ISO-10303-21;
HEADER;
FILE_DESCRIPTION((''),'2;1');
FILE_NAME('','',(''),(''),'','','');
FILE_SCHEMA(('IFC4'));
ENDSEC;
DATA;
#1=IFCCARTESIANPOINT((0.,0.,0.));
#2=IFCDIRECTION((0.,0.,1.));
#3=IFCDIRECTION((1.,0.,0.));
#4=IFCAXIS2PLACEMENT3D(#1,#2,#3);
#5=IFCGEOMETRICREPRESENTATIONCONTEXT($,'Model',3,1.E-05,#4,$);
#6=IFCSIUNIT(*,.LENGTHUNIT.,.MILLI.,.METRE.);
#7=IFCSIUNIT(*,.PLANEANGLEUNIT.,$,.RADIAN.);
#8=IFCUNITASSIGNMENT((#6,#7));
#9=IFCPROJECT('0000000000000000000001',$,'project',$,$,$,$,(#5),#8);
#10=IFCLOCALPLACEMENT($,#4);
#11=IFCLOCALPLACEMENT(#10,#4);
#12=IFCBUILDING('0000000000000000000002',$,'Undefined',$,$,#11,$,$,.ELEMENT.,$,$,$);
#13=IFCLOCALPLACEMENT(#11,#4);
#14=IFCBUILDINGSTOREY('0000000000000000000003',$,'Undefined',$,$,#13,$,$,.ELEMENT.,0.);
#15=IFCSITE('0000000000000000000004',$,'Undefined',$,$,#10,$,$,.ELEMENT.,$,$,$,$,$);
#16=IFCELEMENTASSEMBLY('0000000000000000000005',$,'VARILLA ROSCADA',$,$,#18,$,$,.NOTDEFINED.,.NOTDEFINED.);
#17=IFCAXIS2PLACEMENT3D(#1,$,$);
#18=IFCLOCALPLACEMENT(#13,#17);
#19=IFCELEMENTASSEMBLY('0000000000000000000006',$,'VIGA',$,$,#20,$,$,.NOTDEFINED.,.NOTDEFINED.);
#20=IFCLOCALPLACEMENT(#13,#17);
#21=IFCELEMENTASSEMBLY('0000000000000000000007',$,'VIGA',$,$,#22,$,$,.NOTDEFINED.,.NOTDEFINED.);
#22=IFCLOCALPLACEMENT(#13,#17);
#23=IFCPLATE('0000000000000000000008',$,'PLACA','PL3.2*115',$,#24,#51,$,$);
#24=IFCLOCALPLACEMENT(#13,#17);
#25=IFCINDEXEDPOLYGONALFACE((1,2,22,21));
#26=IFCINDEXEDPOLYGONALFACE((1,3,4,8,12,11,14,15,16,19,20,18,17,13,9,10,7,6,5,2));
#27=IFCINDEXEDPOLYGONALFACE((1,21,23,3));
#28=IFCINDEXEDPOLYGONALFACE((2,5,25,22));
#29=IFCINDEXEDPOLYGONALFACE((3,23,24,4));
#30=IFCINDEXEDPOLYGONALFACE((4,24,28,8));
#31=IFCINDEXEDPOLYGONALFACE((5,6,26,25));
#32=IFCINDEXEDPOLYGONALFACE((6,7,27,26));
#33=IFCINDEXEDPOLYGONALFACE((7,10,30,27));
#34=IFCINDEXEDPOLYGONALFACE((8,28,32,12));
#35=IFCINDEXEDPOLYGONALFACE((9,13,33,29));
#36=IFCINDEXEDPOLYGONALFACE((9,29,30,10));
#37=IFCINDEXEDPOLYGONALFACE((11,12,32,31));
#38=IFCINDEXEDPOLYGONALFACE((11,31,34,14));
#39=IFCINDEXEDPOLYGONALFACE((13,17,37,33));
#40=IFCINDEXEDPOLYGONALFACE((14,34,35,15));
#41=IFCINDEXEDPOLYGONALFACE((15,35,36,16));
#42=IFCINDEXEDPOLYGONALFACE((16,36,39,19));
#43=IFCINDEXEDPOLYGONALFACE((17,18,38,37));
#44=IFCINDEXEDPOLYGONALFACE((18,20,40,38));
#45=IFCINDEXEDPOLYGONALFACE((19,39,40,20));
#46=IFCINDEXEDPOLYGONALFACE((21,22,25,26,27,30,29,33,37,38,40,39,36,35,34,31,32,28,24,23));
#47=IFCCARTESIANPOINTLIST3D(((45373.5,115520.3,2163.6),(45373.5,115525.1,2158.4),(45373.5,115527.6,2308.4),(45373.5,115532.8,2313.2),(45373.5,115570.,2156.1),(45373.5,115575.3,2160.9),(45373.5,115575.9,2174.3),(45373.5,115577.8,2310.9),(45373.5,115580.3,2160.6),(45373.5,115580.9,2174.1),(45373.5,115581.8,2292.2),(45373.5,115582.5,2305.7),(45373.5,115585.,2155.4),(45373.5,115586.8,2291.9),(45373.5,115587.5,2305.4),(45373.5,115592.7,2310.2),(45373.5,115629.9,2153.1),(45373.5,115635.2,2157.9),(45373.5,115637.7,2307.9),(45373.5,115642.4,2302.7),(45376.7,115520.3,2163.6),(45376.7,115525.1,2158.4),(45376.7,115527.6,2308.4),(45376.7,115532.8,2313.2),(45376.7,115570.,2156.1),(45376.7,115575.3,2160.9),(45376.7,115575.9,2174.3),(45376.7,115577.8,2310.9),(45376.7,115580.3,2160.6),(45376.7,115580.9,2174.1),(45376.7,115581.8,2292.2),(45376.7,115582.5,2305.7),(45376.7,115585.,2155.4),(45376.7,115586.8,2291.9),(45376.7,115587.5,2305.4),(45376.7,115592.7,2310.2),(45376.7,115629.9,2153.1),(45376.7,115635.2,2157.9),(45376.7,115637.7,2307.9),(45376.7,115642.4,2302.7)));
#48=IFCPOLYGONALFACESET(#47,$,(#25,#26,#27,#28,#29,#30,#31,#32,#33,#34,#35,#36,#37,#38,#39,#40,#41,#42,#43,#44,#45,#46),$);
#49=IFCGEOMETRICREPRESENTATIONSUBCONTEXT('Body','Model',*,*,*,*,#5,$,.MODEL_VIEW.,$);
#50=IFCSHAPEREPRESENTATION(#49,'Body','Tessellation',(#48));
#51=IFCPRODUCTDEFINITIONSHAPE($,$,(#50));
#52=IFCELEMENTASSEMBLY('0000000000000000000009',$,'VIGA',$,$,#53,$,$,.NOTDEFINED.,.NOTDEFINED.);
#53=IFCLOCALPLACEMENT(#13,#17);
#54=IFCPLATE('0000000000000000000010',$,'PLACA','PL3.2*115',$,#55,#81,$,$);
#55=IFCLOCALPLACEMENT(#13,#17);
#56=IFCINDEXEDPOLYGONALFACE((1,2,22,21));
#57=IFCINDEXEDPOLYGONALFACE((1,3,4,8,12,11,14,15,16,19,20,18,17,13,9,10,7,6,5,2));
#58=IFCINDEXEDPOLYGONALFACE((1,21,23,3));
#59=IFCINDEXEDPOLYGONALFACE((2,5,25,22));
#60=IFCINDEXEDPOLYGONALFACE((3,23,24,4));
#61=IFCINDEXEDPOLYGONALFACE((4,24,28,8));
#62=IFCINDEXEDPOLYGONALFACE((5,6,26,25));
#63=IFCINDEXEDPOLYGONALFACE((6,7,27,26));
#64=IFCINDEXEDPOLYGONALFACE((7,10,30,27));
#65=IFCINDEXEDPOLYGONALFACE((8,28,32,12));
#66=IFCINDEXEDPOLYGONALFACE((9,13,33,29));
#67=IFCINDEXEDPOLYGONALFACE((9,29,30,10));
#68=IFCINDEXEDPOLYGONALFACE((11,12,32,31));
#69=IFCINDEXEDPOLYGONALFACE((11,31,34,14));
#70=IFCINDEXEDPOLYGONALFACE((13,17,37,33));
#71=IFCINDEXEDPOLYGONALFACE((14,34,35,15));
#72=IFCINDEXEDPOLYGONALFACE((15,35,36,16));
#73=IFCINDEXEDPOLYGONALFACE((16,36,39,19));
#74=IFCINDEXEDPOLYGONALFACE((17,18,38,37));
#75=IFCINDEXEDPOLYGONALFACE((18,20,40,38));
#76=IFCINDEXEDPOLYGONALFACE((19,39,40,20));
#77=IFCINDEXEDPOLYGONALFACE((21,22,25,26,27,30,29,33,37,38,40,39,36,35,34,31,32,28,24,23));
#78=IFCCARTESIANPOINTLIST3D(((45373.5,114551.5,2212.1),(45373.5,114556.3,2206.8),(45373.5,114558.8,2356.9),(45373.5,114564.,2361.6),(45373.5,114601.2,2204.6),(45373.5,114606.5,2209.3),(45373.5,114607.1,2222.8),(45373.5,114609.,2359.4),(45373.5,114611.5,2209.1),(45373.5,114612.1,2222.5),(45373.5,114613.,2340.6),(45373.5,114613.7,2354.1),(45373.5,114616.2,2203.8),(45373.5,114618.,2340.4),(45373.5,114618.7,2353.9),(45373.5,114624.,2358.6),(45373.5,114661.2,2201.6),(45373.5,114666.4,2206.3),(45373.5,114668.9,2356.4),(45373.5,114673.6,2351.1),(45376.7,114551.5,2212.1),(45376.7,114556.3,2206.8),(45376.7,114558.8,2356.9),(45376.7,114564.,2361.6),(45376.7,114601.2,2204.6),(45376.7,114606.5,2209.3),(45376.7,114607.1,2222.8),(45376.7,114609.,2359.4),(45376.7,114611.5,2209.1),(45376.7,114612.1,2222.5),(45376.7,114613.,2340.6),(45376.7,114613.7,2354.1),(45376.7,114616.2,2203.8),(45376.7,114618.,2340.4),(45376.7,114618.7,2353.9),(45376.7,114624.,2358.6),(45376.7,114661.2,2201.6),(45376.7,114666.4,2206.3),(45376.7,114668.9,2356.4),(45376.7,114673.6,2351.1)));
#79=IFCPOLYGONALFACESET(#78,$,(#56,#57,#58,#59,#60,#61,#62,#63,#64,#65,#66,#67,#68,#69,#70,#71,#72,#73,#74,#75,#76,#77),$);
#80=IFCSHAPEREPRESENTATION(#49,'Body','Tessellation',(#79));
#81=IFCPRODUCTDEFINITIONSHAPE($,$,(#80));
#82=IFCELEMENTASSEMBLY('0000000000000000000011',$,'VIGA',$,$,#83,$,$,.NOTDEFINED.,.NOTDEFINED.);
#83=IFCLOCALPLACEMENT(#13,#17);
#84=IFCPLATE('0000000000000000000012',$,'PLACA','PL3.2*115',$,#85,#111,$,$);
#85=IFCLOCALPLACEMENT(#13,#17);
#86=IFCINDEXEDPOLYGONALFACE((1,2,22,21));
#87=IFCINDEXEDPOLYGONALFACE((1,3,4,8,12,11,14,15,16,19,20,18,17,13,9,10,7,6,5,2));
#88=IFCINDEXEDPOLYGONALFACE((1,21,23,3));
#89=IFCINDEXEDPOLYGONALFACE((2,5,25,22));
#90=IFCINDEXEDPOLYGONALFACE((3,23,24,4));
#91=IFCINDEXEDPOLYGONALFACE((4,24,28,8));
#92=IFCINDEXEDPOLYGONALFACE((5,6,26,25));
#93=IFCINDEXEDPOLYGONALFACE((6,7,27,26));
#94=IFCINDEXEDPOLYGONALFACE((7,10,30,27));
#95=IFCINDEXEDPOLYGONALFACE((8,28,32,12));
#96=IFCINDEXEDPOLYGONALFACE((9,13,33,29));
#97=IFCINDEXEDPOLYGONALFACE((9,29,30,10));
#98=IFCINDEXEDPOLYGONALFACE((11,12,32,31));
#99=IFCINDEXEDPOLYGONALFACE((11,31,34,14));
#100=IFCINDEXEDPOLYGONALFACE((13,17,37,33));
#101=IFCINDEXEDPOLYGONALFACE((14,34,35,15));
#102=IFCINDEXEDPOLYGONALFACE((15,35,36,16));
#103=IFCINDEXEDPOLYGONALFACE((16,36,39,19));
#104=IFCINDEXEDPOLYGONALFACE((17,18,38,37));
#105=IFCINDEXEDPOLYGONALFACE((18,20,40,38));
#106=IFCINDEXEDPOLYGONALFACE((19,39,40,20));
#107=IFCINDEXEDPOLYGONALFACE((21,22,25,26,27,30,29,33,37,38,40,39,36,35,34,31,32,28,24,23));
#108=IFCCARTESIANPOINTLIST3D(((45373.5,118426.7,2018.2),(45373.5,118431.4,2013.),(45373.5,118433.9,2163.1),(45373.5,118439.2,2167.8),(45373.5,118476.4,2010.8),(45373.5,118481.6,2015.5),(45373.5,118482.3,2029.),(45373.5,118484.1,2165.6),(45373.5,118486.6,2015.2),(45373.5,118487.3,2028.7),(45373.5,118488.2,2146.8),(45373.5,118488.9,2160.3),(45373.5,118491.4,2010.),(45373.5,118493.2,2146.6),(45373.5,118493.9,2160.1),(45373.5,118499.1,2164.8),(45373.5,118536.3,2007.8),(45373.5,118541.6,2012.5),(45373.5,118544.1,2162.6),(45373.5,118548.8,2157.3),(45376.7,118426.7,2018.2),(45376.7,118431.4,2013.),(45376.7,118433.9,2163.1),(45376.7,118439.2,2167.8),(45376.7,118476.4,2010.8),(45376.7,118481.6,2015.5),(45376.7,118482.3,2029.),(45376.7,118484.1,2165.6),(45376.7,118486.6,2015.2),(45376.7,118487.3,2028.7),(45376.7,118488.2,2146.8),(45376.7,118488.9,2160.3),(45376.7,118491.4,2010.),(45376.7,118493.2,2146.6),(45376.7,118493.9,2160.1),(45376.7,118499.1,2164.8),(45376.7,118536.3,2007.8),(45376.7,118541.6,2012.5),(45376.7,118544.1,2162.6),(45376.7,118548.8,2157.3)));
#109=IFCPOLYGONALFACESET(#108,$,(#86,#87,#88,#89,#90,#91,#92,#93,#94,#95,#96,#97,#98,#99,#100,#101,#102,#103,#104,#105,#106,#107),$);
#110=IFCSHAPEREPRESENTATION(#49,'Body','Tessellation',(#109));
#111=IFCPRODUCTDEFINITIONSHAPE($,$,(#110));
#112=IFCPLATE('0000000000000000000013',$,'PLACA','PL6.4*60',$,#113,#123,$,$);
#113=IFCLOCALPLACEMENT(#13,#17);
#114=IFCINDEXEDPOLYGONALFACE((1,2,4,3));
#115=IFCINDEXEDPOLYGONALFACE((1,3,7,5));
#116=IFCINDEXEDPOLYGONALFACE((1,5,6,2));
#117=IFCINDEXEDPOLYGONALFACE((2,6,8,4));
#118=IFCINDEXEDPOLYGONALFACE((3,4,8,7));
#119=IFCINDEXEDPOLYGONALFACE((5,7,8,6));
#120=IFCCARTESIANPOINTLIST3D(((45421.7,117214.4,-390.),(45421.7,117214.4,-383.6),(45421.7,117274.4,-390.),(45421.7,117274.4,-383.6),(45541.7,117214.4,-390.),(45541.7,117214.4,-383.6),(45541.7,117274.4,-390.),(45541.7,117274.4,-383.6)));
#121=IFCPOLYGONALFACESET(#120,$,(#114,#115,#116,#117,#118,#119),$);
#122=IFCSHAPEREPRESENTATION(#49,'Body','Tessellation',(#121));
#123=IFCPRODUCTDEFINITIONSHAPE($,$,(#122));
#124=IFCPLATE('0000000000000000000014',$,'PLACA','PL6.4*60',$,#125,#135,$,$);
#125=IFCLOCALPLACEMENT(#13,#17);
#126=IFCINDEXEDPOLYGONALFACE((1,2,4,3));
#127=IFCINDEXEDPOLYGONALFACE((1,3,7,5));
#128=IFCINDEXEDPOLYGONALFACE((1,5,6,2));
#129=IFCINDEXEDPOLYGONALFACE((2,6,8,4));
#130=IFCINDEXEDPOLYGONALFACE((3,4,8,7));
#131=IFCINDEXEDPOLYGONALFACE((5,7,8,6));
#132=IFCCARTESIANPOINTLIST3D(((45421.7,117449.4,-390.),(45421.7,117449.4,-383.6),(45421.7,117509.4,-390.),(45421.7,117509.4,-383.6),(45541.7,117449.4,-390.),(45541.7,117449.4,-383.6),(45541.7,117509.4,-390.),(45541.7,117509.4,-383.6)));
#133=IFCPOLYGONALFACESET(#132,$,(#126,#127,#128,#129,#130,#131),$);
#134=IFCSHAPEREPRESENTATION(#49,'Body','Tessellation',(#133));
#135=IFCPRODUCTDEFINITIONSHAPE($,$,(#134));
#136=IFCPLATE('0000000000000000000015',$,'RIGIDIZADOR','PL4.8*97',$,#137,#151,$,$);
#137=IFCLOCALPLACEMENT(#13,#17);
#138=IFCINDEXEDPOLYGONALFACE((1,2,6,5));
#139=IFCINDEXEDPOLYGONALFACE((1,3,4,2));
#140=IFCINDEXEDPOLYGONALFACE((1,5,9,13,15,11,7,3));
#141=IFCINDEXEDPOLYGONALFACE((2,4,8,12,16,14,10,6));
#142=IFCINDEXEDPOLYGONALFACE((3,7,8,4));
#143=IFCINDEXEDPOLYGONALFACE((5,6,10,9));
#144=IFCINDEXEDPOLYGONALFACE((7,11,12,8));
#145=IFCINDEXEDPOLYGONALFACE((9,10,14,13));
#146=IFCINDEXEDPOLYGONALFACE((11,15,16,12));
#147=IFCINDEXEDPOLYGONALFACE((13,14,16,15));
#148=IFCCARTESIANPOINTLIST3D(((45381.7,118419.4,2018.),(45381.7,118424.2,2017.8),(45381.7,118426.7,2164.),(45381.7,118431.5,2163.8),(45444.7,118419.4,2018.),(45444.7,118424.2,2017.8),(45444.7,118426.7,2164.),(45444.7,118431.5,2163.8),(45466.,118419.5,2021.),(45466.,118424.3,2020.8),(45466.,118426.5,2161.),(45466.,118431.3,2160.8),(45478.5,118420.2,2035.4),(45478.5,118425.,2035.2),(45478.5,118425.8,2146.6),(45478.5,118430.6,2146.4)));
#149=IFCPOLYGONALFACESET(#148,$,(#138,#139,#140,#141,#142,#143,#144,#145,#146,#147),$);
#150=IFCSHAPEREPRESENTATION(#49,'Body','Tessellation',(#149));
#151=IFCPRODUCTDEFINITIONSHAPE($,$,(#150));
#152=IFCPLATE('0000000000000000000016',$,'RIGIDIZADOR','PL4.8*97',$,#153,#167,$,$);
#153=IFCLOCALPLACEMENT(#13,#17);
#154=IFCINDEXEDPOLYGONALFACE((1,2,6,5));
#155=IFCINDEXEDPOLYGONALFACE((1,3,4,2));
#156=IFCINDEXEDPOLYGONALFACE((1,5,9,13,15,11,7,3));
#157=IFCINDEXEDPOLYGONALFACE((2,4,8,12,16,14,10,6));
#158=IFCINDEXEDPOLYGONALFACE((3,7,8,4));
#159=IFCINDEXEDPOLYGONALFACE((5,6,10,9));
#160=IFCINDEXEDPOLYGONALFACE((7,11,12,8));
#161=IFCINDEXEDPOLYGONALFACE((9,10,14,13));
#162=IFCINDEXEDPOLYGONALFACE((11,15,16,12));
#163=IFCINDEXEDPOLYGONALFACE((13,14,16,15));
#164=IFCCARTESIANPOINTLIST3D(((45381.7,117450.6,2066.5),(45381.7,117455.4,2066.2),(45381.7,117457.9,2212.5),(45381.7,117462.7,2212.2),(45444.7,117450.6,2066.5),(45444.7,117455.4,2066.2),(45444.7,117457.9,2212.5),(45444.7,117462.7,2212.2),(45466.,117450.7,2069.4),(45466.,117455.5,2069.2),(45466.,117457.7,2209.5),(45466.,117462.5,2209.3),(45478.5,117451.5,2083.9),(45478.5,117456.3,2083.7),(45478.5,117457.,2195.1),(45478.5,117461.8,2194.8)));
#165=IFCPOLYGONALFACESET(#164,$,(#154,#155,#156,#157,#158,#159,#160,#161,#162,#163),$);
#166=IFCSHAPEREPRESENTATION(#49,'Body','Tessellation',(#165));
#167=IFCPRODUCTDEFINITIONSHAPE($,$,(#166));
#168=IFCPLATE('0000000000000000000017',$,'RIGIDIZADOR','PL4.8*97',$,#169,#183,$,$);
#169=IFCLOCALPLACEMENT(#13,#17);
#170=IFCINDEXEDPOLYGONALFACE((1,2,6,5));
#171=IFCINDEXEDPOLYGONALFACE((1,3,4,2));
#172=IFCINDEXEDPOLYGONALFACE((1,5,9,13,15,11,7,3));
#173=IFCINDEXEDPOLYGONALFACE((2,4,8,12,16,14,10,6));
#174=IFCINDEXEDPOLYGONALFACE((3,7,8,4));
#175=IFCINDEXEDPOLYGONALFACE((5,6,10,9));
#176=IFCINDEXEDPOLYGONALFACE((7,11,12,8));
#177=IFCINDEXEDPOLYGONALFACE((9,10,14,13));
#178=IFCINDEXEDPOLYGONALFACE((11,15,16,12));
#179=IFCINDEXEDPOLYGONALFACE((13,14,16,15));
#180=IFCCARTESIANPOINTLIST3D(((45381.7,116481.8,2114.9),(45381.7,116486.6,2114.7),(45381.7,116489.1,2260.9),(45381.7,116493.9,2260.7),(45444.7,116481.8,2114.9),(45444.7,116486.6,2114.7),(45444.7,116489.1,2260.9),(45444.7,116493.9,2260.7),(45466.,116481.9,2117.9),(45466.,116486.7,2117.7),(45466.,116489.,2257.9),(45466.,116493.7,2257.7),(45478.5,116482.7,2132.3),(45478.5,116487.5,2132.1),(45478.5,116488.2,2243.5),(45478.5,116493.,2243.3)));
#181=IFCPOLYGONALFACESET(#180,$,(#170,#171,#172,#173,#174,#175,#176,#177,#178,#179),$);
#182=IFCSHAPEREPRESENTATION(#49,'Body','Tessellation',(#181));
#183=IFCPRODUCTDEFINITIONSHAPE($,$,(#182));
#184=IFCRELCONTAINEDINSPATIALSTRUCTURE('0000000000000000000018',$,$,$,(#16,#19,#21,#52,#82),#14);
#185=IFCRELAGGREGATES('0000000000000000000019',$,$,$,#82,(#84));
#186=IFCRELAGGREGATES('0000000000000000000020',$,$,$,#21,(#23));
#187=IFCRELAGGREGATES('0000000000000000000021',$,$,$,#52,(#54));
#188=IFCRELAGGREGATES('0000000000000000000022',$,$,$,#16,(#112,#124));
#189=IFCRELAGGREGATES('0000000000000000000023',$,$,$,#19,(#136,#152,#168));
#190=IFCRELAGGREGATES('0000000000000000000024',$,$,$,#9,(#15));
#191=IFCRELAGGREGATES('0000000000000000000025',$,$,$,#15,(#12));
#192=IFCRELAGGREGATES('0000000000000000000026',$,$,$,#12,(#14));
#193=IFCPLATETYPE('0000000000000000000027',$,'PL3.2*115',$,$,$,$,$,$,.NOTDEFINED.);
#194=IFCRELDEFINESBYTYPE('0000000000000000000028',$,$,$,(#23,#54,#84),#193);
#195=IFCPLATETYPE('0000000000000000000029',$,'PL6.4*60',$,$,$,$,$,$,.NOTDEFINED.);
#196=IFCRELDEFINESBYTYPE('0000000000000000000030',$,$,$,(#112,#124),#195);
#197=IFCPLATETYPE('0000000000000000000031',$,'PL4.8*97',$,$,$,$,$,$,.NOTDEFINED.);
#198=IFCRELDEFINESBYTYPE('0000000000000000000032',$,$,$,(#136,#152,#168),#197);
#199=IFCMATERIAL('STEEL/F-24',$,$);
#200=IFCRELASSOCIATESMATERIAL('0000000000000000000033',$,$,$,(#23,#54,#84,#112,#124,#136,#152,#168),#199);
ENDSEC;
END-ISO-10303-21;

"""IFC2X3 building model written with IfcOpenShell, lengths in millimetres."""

from ifc_helpers import new_model, si_unit, frame, origin_with_axes, place, context, subcontext, project, spatial, polyline, outline, extrude, material, type_object, element, aggregate, save


model = new_model("IFC2X3")

# Units and contexts
model_context = context("Model", 3, precision=1e-05, world=origin_with_axes())
body_context = subcontext(model_context, "Body", "Model", "MODEL_VIEW")
ifc_project = project(units=[si_unit("LENGTHUNIT", "METRE", prefix="MILLI"), si_unit("PLANEANGLEUNIT", "RADIAN")], contexts=[model_context])

# Site, building, storey
site_placement = place(None, origin_with_axes())
site = spatial("IfcSite", under=ifc_project, at=site_placement, Name="Undefined", CompositionType="ELEMENT")
building_placement = place(site_placement, origin_with_axes())
building = spatial("IfcBuilding", under=site, at=building_placement, Name="Undefined", CompositionType="ELEMENT")
storey_placement = place(building_placement, origin_with_axes())
storey = spatial("IfcBuildingStorey", under=building, at=storey_placement, Name="Undefined", CompositionType="ELEMENT", Elevation=0.0)

# Element assembly
assembly_1_placement = place(storey_placement, origin_with_axes())
assembly_1 = element("IfcElementAssembly", 1, at=assembly_1_placement, inside=storey, Name="VARILLA ROSCADA", AssemblyPlace="NOTDEFINED", PredefinedType="NOTDEFINED")

# Element assembly
assembly_2_placement = place(storey_placement, origin_with_axes())
assembly_2 = element("IfcElementAssembly", 2, at=assembly_2_placement, inside=storey, Name="VIGA", AssemblyPlace="NOTDEFINED", PredefinedType="NOTDEFINED")
ifc_material_1 = material(Name="STEEL/F-24")

# Element assemblies, plates
plate_type_1 = type_object("IfcPlateType", Name="PL3.2*115", PredefinedType="NOTDEFINED")
assembly_3_placement = place(storey_placement, origin_with_axes())
assembly_3 = element("IfcElementAssembly", 3, at=assembly_3_placement, inside=storey, Name="VIGA", AssemblyPlace="NOTDEFINED", PredefinedType="NOTDEFINED")
plate_1_placement = place(assembly_3_placement, frame((45375.1, 115642.7, 2307.7), z_axis=(1.0, 0.0, 0.0), x_axis=(0.0, -0.998752, 0.04995)))
plate_1 = element("IfcPlate", 4, at=plate_1_placement, type_object=plate_type_1, material=ifc_material_1, Name="PLACA", Description="PL3.2*115", context=body_context, shape_type="SweptSolid", body=[
    extrude(outline(polyline([(0.0, 5.0), (5.0, 0.0), (50.0, 0.0), (55.0, 5.0), (55.0, 18.5), (60.0, 18.5), (60.0, 5.0), (65.0, 0.0), (110.0, 0.0), (115.0, 5.0), (115.0, 150.0), (110.0, 155.0), (65.0, 155.0), (60.0, 150.0), (60.0, 136.5), (55.0, 136.5), (55.0, 150.0), (50.0, 155.0), (5.0, 155.0), (0.0, 150.0), (0.0, 5.0)])), frame((0.0, 0.0, -1.6), z_axis=(0.0, 0.0, 1.0), x_axis=(1.0, 0.0, 0.0)), (0.0, 0.0, 1.0), 3.2),
])
assembly_4_placement = place(storey_placement, origin_with_axes())
assembly_4 = element("IfcElementAssembly", 5, at=assembly_4_placement, inside=storey, Name="VIGA", AssemblyPlace="NOTDEFINED", PredefinedType="NOTDEFINED")
plate_2_placement = place(assembly_4_placement, frame((45375.1, 114673.9, 2356.1), z_axis=(1.0, 0.0, 0.0), x_axis=(0.0, -0.998752, 0.04995)))
plate_2 = element("IfcPlate", 6, at=plate_2_placement, type_object=plate_type_1, material=ifc_material_1, Name="PLACA", Description="PL3.2*115", context=body_context, shape_type="SweptSolid", body=[
    extrude(outline(polyline([(0.0, 5.0), (5.0, 0.0), (50.0, 0.0), (55.0, 5.0), (55.0, 18.5), (60.0, 18.5), (60.0, 5.0), (65.0, 0.0), (110.0, 0.0), (115.0, 5.0), (115.0, 150.0), (110.0, 155.0), (65.0, 155.0), (60.0, 150.0), (60.0, 136.5), (55.0, 136.5), (55.0, 150.0), (50.0, 155.0), (5.0, 155.0), (0.0, 150.0), (0.0, 5.0)])), frame((0.0, 0.0, -1.6), z_axis=(0.0, 0.0, 1.0), x_axis=(1.0, 0.0, 0.0)), (0.0, 0.0, 1.0), 3.2),
])
assembly_5_placement = place(storey_placement, origin_with_axes())
assembly_5 = element("IfcElementAssembly", 7, at=assembly_5_placement, inside=storey, Name="VIGA", AssemblyPlace="NOTDEFINED", PredefinedType="NOTDEFINED")
plate_3_placement = place(assembly_5_placement, frame((45375.1, 118549.0, 2162.3), z_axis=(1.0, 0.0, 0.0), x_axis=(0.0, -0.998752, 0.04995)))
plate_3 = element("IfcPlate", 8, at=plate_3_placement, type_object=plate_type_1, material=ifc_material_1, Name="PLACA", Description="PL3.2*115", context=body_context, shape_type="SweptSolid", body=[
    extrude(outline(polyline([(0.0, 5.0), (5.0, 0.0), (50.0, 0.0), (55.0, 5.0), (55.0, 18.5), (60.0, 18.5), (60.0, 5.0), (65.0, 0.0), (110.0, 0.0), (115.0, 5.0), (115.0, 150.0), (110.0, 155.0), (65.0, 155.0), (60.0, 150.0), (60.0, 136.5), (55.0, 136.5), (55.0, 150.0), (50.0, 155.0), (5.0, 155.0), (0.0, 150.0), (0.0, 5.0)])), frame((0.0, 0.0, -1.6), z_axis=(0.0, 0.0, 1.0), x_axis=(1.0, 0.0, 0.0)), (0.0, 0.0, 1.0), 3.2),
])

# Plates
plate_type_2 = type_object("IfcPlateType", Name="PL6.4*60", PredefinedType="NOTDEFINED")
plate_4_placement = place(assembly_1_placement, frame((45421.7, 117214.4, -386.8), z_axis=(0.0, 0.0, 1.0), x_axis=(1.0, 0.0, 0.0)))
plate_4 = element("IfcPlate", 9, at=plate_4_placement, type_object=plate_type_2, material=ifc_material_1, Name="PLACA", Description="PL6.4*60", context=body_context, shape_type="SweptSolid", body=[
    extrude(outline(polyline([(0.0, 0.0), (120.0, 0.0), (120.0, 60.0), (0.0, 60.0), (0.0, 0.0)])), frame((0.0, 0.0, -3.2), z_axis=(0.0, 0.0, 1.0), x_axis=(1.0, 0.0, 0.0)), (0.0, 0.0, 1.0), 6.4),
])
plate_5_placement = place(assembly_1_placement, frame((45421.7, 117449.4, -386.8), z_axis=(0.0, 0.0, 1.0), x_axis=(1.0, 0.0, 0.0)))
plate_5 = element("IfcPlate", 10, at=plate_5_placement, type_object=plate_type_2, material=ifc_material_1, Name="PLACA", Description="PL6.4*60", context=body_context, shape_type="SweptSolid", body=[
    extrude(outline(polyline([(0.0, 0.0), (120.0, 0.0), (120.0, 60.0), (0.0, 60.0), (0.0, 0.0)])), frame((0.0, 0.0, -3.2), z_axis=(0.0, 0.0, 1.0), x_axis=(1.0, 0.0, 0.0)), (0.0, 0.0, 1.0), 6.4),
])
plate_type_3 = type_object("IfcPlateType", Name="PL4.8*97", PredefinedType="NOTDEFINED")
plate_6_placement = place(assembly_2_placement, frame((45381.7, 118429.1, 2163.9), z_axis=(0.0, 0.998752, -0.04995), x_axis=(1.0, 0.0, 0.0)))
plate_6 = element("IfcPlate", 11, at=plate_6_placement, type_object=plate_type_3, material=ifc_material_1, Name="RIGIDIZADOR", Description="PL4.8*97", context=body_context, shape_type="SweptSolid", body=[
    extrude(outline(polyline([(0.0, 0.0), (63.0, 0.0), (84.3, 3.0), (96.8, 17.4), (96.8, 128.7), (84.3, 143.2), (63.0, 146.2), (0.0, 146.2), (0.0, 0.0)])), frame((0.0, 0.0, -2.4), z_axis=(0.0, 0.0, 1.0), x_axis=(1.0, 0.0, 0.0)), (0.0, 0.0, 1.0), 4.8),
])
plate_7_placement = place(assembly_2_placement, frame((45381.7, 117460.3, 2212.4), z_axis=(0.0, 0.998752, -0.04995), x_axis=(1.0, 0.0, 0.0)))
plate_7 = element("IfcPlate", 12, at=plate_7_placement, type_object=plate_type_3, material=ifc_material_1, Name="RIGIDIZADOR", Description="PL4.8*97", context=body_context, shape_type="SweptSolid", body=[
    extrude(outline(polyline([(0.0, 0.0), (63.0, 0.0), (84.3, 3.0), (96.8, 17.4), (96.8, 128.7), (84.3, 143.2), (63.0, 146.2), (0.0, 146.2), (0.0, 0.0)])), frame((0.0, 0.0, -2.4), z_axis=(0.0, 0.0, 1.0), x_axis=(1.0, 0.0, 0.0)), (0.0, 0.0, 1.0), 4.8),
])
plate_8_placement = place(assembly_2_placement, frame((45381.7, 116491.5, 2260.8), z_axis=(0.0, 0.998752, -0.04995), x_axis=(1.0, 0.0, 0.0)))
plate_8 = element("IfcPlate", 13, at=plate_8_placement, type_object=plate_type_3, material=ifc_material_1, Name="RIGIDIZADOR", Description="PL4.8*97", context=body_context, shape_type="SweptSolid", body=[
    extrude(outline(polyline([(0.0, 0.0), (63.0, 0.0), (84.3, 3.0), (96.8, 17.4), (96.8, 128.7), (84.3, 143.2), (63.0, 146.2), (0.0, 146.2), (0.0, 0.0)])), frame((0.0, 0.0, -2.4), z_axis=(0.0, 0.0, 1.0), x_axis=(1.0, 0.0, 0.0)), (0.0, 0.0, 1.0), 4.8),
])

aggregate(assembly_5, [plate_3])
aggregate(assembly_3, [plate_1])
aggregate(assembly_4, [plate_2])

aggregate(assembly_1, [plate_4, plate_5])

aggregate(assembly_2, [plate_6, plate_7, plate_8])

save(model, "model.ifc")
